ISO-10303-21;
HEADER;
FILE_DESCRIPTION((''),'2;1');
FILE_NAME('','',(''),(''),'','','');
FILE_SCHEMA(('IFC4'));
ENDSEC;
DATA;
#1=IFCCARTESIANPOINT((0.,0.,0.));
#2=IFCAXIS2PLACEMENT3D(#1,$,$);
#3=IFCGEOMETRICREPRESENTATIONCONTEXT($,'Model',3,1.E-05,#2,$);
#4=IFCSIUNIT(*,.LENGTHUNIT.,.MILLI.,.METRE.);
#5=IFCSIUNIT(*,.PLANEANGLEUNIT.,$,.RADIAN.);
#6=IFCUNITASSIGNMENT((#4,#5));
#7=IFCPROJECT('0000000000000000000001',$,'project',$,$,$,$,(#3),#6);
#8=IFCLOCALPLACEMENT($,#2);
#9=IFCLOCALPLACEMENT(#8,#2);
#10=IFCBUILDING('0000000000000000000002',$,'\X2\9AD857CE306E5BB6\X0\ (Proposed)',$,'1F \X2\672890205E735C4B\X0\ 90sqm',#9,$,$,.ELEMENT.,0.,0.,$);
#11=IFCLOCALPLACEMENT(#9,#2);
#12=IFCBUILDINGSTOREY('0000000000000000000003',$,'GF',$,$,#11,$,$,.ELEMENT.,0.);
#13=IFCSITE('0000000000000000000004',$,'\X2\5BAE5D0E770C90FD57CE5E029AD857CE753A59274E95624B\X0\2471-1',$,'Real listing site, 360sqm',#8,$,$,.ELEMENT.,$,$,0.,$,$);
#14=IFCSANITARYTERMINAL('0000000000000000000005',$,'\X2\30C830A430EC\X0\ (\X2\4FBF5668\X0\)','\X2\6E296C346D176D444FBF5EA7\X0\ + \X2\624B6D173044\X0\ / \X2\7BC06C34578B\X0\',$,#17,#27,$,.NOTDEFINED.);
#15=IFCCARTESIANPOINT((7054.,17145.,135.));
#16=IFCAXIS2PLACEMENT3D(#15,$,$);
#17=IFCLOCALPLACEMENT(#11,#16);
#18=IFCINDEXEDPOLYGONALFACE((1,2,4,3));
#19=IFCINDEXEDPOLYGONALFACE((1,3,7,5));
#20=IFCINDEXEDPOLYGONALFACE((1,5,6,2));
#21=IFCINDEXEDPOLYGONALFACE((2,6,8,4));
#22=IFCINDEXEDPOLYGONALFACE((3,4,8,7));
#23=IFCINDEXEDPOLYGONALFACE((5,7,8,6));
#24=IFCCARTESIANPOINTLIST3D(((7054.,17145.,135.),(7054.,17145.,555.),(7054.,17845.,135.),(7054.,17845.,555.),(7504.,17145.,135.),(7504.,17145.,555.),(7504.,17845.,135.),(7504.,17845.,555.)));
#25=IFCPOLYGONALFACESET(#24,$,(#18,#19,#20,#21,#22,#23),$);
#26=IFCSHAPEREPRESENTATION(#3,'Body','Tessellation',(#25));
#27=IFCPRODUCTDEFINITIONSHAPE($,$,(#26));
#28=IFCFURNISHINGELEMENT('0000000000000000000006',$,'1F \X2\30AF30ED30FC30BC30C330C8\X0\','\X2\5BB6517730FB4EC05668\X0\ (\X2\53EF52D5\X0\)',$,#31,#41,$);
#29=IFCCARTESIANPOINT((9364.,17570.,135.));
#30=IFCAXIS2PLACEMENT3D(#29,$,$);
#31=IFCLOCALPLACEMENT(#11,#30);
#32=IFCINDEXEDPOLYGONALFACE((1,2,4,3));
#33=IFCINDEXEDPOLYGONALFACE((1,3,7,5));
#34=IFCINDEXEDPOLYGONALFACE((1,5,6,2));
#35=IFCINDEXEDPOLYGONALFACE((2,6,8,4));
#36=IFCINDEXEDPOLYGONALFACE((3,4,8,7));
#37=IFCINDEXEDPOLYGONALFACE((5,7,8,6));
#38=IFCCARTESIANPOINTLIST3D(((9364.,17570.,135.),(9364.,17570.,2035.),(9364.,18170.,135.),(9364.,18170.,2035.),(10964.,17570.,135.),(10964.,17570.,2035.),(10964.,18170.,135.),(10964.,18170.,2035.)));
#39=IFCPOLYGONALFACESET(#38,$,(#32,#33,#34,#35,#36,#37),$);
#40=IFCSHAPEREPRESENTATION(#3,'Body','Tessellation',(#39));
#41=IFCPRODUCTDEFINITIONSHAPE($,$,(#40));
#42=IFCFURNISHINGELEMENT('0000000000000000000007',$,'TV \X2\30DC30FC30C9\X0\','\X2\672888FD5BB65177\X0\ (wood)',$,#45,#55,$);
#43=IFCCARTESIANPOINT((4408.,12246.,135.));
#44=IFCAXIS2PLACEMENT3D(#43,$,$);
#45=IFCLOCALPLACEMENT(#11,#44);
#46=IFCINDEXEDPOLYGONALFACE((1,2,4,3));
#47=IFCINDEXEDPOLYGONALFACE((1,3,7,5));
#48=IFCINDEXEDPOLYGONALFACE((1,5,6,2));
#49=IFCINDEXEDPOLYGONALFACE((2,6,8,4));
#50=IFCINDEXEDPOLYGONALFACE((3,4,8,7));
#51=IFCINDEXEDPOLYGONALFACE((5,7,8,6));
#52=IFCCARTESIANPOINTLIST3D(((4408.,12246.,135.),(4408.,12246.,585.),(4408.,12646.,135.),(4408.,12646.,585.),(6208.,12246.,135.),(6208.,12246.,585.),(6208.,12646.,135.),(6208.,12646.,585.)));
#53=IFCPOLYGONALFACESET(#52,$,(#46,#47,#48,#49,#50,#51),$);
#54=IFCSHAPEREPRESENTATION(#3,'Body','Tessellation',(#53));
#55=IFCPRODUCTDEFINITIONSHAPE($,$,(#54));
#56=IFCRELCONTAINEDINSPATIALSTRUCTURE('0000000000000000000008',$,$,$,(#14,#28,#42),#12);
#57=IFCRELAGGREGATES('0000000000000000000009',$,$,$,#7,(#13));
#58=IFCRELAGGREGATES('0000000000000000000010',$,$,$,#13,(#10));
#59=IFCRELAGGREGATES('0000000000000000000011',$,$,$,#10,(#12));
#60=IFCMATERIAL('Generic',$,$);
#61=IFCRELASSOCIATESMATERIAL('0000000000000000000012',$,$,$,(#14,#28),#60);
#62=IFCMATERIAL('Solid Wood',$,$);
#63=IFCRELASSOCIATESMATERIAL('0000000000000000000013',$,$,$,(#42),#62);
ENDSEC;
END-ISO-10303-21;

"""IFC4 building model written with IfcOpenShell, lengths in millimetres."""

from ifc_helpers import new_model, si_unit, frame, frame_2d, origin, place, context, project, spatial, rectangle, extrude, material, element, save


model = new_model("IFC4")

# Units and contexts
model_context = context("Model", 3, precision=1e-05, world=origin())
ifc_project = project(units=[si_unit("LENGTHUNIT", "METRE", prefix="MILLI"), si_unit("PLANEANGLEUNIT", "RADIAN")], contexts=[model_context])

# Site, building, storey
site_placement = place(None, origin())
site = spatial("IfcSite", under=ifc_project, at=site_placement, Name="宮崎県都城市高城町大井手2471-1", ObjectType="Real listing site, 360sqm", CompositionType="ELEMENT", RefElevation=0.0)
building_placement = place(site_placement, origin())
building = spatial("IfcBuilding", under=site, at=building_placement, Name="高城の家 (Proposed)", ObjectType="1F 木造平屋 90sqm", CompositionType="ELEMENT", ElevationOfRefHeight=0.0, ElevationOfTerrain=0.0)
storey_placement = place(building_placement, origin())
storey = spatial("IfcBuildingStorey", under=building, at=storey_placement, Name="GF", CompositionType="ELEMENT", Elevation=0.0)

# Shared definitions
ifc_material_1 = material(Name="Solid Wood")

# Sanitary terminal
ifc_material_2 = material(Name="Generic")
sanitary_terminal_1_placement = place(storey_placement, frame((7054.0, 17145.0, 135.0)))
element("IfcSanitaryTerminal", 1, at=sanitary_terminal_1_placement, inside=storey, material=ifc_material_2, Name="トイレ (便器)", Description="温水洗浄便座 + 手洗い / 節水型", PredefinedType="NOTDEFINED", context=model_context, shape_type="SweptSolid", body=[
    extrude(rectangle(XDim=450.0, YDim=700.0, at=frame_2d((225.0, 350.0))), frame((7054.0, 17145.0, 135.0)), (0.0, 0.0, 1.0), 420.0),
])

# Furnishing elements
furnishing_1_placement = place(storey_placement, frame((9364.0, 17570.0, 135.0)))
element("IfcFurnishingElement", 2, at=furnishing_1_placement, inside=storey, material=ifc_material_2, Name="1F クローゼット", Description="家具・什器 (可動)", context=model_context, shape_type="SweptSolid", body=[
    extrude(rectangle(XDim=1600.0, YDim=600.0, at=frame_2d((800.0, 300.0))), frame((9364.0, 17570.0, 135.0)), (0.0, 0.0, 1.0), 1900.0),
])
furnishing_2_placement = place(storey_placement, frame((4408.0, 12246.0, 135.0)))
element("IfcFurnishingElement", 3, at=furnishing_2_placement, inside=storey, material=ifc_material_1, Name="TV ボード", Description="木製家具 (wood)", context=model_context, shape_type="SweptSolid", body=[
    extrude(rectangle(XDim=1800.0, YDim=400.0, at=frame_2d((900.0, 200.0))), frame((4408.0, 12246.0, 135.0)), (0.0, 0.0, 1.0), 450.0),
])

save(model, "model.ifc")
